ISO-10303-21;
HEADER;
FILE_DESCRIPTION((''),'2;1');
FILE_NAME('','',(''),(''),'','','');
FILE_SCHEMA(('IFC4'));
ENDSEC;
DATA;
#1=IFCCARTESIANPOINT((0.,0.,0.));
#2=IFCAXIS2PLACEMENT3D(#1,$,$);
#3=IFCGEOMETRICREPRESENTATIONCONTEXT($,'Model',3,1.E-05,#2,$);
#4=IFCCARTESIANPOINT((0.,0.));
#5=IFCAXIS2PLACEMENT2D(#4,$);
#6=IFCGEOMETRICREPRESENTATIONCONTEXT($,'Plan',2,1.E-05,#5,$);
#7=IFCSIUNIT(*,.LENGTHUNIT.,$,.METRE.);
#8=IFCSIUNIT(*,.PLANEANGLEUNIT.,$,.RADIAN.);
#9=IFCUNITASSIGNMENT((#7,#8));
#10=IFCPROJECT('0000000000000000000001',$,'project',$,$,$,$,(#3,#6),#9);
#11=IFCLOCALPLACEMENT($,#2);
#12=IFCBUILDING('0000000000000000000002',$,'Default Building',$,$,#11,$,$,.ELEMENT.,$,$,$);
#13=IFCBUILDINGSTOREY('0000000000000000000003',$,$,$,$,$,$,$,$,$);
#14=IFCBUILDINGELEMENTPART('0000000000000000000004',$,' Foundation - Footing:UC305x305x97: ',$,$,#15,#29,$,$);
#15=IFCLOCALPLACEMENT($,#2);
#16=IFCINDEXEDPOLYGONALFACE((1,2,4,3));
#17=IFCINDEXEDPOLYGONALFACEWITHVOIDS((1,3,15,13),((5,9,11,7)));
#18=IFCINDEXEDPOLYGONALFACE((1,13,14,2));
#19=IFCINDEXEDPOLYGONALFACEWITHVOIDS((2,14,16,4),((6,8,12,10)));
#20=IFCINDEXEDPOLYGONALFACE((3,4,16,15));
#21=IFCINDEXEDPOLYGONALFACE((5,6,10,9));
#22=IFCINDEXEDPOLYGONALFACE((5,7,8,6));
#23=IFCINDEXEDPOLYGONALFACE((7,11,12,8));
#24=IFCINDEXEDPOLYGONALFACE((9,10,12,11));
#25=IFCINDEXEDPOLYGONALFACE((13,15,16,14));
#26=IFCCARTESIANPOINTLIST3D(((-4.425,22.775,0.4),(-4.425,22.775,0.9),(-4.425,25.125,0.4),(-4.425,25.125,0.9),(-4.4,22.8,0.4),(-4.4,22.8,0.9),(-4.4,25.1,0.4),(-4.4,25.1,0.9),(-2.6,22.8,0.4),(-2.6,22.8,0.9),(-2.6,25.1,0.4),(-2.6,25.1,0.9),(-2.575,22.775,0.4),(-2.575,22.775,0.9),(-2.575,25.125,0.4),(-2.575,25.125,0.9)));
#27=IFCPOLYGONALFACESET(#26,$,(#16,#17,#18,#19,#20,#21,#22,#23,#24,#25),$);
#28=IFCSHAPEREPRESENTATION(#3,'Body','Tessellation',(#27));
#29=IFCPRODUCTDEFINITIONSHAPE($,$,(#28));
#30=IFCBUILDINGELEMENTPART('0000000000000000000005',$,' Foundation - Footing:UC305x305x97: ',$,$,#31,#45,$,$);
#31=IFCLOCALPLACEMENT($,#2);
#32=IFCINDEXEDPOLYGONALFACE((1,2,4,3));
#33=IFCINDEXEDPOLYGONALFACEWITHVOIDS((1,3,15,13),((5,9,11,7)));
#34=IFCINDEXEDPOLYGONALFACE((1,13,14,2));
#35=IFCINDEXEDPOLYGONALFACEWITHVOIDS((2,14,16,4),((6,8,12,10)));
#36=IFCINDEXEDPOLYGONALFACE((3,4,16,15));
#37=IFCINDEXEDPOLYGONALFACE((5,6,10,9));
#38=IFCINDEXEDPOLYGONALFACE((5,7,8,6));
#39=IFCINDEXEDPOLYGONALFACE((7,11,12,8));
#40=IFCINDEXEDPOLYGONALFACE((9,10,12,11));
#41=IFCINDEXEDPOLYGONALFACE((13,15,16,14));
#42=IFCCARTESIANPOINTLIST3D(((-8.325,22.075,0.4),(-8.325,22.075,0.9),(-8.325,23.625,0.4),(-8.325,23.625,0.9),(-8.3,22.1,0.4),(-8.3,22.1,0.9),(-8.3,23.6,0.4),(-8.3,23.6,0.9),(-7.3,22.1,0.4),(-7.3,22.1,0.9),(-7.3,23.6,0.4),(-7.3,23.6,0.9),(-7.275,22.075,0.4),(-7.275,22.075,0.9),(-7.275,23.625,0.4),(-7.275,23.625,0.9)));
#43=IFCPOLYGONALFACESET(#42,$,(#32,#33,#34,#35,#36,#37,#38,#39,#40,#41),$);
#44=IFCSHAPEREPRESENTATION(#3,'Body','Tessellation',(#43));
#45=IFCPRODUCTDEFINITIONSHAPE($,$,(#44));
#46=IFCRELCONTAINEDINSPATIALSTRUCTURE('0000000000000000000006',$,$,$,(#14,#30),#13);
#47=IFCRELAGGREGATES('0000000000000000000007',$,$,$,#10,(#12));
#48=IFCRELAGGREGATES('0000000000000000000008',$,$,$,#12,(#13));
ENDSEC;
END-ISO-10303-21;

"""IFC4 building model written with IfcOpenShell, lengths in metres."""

from ifc_helpers import new_model, si_unit, origin, origin_2d, place, context, project, spatial, polyline, outline, extrude, element, save


model = new_model("IFC4")

# Units and contexts
model_context = context("Model", 3, precision=1e-05, world=origin())
plan_context = context("Plan", 2, precision=1e-05, world=origin_2d())
ifc_project = project(units=[si_unit("LENGTHUNIT", "METRE"), si_unit("PLANEANGLEUNIT", "RADIAN")], contexts=[model_context, plan_context])

# Building, storey
building_placement = place(None, origin())
building = spatial("IfcBuilding", under=ifc_project, at=building_placement, Name="Default Building", CompositionType="ELEMENT")
storey = spatial("IfcBuildingStorey", under=building)

# Building element parts, openings
building_element_part_1 = element("IfcBuildingElementPart", 1, inside=storey, Name=" Foundation - Footing:UC305x305x97: ", context=model_context, shape_type="SweptSolid", body=[
    extrude(outline(polyline([(-4.425, 25.125, 0.4), (-2.575, 25.125, 0.4), (-2.575, 22.775, 0.4), (-4.425, 22.775, 0.4), (-4.425, 25.125, 0.4)])), None, (0.0, 0.0, 1.0), 0.5),
])
element("IfcOpeningElement", 2, inside=storey, cuts=building_element_part_1, context=model_context, shape_type="SweptSolid", body=[
    extrude(outline(polyline([(-4.4, 25.1, 0.4), (-2.6, 25.1, 0.4), (-2.6, 22.8, 0.4), (-4.4, 22.8, 0.4), (-4.4, 25.1, 0.4)])), None, (0.0, 0.0, 1.0), 0.5),
])
building_element_part_2 = element("IfcBuildingElementPart", 3, inside=storey, Name=" Foundation - Footing:UC305x305x97: ", context=model_context, shape_type="SweptSolid", body=[
    extrude(outline(polyline([(-7.275, 23.625, 0.4), (-8.325, 23.625, 0.4), (-8.325, 22.075, 0.4), (-7.275, 22.075, 0.4), (-7.275, 23.625, 0.4)])), None, (0.0, 0.0, 1.0), 0.5),
])
element("IfcOpeningElement", 4, inside=storey, cuts=building_element_part_2, context=model_context, shape_type="SweptSolid", body=[
    extrude(outline(polyline([(-7.3, 23.6, 0.4), (-8.3, 23.6, 0.4), (-8.3, 22.1, 0.4), (-7.3, 22.1, 0.4), (-7.3, 23.6, 0.4)])), None, (0.0, 0.0, 1.0), 0.5),
])

save(model, "model.ifc")
